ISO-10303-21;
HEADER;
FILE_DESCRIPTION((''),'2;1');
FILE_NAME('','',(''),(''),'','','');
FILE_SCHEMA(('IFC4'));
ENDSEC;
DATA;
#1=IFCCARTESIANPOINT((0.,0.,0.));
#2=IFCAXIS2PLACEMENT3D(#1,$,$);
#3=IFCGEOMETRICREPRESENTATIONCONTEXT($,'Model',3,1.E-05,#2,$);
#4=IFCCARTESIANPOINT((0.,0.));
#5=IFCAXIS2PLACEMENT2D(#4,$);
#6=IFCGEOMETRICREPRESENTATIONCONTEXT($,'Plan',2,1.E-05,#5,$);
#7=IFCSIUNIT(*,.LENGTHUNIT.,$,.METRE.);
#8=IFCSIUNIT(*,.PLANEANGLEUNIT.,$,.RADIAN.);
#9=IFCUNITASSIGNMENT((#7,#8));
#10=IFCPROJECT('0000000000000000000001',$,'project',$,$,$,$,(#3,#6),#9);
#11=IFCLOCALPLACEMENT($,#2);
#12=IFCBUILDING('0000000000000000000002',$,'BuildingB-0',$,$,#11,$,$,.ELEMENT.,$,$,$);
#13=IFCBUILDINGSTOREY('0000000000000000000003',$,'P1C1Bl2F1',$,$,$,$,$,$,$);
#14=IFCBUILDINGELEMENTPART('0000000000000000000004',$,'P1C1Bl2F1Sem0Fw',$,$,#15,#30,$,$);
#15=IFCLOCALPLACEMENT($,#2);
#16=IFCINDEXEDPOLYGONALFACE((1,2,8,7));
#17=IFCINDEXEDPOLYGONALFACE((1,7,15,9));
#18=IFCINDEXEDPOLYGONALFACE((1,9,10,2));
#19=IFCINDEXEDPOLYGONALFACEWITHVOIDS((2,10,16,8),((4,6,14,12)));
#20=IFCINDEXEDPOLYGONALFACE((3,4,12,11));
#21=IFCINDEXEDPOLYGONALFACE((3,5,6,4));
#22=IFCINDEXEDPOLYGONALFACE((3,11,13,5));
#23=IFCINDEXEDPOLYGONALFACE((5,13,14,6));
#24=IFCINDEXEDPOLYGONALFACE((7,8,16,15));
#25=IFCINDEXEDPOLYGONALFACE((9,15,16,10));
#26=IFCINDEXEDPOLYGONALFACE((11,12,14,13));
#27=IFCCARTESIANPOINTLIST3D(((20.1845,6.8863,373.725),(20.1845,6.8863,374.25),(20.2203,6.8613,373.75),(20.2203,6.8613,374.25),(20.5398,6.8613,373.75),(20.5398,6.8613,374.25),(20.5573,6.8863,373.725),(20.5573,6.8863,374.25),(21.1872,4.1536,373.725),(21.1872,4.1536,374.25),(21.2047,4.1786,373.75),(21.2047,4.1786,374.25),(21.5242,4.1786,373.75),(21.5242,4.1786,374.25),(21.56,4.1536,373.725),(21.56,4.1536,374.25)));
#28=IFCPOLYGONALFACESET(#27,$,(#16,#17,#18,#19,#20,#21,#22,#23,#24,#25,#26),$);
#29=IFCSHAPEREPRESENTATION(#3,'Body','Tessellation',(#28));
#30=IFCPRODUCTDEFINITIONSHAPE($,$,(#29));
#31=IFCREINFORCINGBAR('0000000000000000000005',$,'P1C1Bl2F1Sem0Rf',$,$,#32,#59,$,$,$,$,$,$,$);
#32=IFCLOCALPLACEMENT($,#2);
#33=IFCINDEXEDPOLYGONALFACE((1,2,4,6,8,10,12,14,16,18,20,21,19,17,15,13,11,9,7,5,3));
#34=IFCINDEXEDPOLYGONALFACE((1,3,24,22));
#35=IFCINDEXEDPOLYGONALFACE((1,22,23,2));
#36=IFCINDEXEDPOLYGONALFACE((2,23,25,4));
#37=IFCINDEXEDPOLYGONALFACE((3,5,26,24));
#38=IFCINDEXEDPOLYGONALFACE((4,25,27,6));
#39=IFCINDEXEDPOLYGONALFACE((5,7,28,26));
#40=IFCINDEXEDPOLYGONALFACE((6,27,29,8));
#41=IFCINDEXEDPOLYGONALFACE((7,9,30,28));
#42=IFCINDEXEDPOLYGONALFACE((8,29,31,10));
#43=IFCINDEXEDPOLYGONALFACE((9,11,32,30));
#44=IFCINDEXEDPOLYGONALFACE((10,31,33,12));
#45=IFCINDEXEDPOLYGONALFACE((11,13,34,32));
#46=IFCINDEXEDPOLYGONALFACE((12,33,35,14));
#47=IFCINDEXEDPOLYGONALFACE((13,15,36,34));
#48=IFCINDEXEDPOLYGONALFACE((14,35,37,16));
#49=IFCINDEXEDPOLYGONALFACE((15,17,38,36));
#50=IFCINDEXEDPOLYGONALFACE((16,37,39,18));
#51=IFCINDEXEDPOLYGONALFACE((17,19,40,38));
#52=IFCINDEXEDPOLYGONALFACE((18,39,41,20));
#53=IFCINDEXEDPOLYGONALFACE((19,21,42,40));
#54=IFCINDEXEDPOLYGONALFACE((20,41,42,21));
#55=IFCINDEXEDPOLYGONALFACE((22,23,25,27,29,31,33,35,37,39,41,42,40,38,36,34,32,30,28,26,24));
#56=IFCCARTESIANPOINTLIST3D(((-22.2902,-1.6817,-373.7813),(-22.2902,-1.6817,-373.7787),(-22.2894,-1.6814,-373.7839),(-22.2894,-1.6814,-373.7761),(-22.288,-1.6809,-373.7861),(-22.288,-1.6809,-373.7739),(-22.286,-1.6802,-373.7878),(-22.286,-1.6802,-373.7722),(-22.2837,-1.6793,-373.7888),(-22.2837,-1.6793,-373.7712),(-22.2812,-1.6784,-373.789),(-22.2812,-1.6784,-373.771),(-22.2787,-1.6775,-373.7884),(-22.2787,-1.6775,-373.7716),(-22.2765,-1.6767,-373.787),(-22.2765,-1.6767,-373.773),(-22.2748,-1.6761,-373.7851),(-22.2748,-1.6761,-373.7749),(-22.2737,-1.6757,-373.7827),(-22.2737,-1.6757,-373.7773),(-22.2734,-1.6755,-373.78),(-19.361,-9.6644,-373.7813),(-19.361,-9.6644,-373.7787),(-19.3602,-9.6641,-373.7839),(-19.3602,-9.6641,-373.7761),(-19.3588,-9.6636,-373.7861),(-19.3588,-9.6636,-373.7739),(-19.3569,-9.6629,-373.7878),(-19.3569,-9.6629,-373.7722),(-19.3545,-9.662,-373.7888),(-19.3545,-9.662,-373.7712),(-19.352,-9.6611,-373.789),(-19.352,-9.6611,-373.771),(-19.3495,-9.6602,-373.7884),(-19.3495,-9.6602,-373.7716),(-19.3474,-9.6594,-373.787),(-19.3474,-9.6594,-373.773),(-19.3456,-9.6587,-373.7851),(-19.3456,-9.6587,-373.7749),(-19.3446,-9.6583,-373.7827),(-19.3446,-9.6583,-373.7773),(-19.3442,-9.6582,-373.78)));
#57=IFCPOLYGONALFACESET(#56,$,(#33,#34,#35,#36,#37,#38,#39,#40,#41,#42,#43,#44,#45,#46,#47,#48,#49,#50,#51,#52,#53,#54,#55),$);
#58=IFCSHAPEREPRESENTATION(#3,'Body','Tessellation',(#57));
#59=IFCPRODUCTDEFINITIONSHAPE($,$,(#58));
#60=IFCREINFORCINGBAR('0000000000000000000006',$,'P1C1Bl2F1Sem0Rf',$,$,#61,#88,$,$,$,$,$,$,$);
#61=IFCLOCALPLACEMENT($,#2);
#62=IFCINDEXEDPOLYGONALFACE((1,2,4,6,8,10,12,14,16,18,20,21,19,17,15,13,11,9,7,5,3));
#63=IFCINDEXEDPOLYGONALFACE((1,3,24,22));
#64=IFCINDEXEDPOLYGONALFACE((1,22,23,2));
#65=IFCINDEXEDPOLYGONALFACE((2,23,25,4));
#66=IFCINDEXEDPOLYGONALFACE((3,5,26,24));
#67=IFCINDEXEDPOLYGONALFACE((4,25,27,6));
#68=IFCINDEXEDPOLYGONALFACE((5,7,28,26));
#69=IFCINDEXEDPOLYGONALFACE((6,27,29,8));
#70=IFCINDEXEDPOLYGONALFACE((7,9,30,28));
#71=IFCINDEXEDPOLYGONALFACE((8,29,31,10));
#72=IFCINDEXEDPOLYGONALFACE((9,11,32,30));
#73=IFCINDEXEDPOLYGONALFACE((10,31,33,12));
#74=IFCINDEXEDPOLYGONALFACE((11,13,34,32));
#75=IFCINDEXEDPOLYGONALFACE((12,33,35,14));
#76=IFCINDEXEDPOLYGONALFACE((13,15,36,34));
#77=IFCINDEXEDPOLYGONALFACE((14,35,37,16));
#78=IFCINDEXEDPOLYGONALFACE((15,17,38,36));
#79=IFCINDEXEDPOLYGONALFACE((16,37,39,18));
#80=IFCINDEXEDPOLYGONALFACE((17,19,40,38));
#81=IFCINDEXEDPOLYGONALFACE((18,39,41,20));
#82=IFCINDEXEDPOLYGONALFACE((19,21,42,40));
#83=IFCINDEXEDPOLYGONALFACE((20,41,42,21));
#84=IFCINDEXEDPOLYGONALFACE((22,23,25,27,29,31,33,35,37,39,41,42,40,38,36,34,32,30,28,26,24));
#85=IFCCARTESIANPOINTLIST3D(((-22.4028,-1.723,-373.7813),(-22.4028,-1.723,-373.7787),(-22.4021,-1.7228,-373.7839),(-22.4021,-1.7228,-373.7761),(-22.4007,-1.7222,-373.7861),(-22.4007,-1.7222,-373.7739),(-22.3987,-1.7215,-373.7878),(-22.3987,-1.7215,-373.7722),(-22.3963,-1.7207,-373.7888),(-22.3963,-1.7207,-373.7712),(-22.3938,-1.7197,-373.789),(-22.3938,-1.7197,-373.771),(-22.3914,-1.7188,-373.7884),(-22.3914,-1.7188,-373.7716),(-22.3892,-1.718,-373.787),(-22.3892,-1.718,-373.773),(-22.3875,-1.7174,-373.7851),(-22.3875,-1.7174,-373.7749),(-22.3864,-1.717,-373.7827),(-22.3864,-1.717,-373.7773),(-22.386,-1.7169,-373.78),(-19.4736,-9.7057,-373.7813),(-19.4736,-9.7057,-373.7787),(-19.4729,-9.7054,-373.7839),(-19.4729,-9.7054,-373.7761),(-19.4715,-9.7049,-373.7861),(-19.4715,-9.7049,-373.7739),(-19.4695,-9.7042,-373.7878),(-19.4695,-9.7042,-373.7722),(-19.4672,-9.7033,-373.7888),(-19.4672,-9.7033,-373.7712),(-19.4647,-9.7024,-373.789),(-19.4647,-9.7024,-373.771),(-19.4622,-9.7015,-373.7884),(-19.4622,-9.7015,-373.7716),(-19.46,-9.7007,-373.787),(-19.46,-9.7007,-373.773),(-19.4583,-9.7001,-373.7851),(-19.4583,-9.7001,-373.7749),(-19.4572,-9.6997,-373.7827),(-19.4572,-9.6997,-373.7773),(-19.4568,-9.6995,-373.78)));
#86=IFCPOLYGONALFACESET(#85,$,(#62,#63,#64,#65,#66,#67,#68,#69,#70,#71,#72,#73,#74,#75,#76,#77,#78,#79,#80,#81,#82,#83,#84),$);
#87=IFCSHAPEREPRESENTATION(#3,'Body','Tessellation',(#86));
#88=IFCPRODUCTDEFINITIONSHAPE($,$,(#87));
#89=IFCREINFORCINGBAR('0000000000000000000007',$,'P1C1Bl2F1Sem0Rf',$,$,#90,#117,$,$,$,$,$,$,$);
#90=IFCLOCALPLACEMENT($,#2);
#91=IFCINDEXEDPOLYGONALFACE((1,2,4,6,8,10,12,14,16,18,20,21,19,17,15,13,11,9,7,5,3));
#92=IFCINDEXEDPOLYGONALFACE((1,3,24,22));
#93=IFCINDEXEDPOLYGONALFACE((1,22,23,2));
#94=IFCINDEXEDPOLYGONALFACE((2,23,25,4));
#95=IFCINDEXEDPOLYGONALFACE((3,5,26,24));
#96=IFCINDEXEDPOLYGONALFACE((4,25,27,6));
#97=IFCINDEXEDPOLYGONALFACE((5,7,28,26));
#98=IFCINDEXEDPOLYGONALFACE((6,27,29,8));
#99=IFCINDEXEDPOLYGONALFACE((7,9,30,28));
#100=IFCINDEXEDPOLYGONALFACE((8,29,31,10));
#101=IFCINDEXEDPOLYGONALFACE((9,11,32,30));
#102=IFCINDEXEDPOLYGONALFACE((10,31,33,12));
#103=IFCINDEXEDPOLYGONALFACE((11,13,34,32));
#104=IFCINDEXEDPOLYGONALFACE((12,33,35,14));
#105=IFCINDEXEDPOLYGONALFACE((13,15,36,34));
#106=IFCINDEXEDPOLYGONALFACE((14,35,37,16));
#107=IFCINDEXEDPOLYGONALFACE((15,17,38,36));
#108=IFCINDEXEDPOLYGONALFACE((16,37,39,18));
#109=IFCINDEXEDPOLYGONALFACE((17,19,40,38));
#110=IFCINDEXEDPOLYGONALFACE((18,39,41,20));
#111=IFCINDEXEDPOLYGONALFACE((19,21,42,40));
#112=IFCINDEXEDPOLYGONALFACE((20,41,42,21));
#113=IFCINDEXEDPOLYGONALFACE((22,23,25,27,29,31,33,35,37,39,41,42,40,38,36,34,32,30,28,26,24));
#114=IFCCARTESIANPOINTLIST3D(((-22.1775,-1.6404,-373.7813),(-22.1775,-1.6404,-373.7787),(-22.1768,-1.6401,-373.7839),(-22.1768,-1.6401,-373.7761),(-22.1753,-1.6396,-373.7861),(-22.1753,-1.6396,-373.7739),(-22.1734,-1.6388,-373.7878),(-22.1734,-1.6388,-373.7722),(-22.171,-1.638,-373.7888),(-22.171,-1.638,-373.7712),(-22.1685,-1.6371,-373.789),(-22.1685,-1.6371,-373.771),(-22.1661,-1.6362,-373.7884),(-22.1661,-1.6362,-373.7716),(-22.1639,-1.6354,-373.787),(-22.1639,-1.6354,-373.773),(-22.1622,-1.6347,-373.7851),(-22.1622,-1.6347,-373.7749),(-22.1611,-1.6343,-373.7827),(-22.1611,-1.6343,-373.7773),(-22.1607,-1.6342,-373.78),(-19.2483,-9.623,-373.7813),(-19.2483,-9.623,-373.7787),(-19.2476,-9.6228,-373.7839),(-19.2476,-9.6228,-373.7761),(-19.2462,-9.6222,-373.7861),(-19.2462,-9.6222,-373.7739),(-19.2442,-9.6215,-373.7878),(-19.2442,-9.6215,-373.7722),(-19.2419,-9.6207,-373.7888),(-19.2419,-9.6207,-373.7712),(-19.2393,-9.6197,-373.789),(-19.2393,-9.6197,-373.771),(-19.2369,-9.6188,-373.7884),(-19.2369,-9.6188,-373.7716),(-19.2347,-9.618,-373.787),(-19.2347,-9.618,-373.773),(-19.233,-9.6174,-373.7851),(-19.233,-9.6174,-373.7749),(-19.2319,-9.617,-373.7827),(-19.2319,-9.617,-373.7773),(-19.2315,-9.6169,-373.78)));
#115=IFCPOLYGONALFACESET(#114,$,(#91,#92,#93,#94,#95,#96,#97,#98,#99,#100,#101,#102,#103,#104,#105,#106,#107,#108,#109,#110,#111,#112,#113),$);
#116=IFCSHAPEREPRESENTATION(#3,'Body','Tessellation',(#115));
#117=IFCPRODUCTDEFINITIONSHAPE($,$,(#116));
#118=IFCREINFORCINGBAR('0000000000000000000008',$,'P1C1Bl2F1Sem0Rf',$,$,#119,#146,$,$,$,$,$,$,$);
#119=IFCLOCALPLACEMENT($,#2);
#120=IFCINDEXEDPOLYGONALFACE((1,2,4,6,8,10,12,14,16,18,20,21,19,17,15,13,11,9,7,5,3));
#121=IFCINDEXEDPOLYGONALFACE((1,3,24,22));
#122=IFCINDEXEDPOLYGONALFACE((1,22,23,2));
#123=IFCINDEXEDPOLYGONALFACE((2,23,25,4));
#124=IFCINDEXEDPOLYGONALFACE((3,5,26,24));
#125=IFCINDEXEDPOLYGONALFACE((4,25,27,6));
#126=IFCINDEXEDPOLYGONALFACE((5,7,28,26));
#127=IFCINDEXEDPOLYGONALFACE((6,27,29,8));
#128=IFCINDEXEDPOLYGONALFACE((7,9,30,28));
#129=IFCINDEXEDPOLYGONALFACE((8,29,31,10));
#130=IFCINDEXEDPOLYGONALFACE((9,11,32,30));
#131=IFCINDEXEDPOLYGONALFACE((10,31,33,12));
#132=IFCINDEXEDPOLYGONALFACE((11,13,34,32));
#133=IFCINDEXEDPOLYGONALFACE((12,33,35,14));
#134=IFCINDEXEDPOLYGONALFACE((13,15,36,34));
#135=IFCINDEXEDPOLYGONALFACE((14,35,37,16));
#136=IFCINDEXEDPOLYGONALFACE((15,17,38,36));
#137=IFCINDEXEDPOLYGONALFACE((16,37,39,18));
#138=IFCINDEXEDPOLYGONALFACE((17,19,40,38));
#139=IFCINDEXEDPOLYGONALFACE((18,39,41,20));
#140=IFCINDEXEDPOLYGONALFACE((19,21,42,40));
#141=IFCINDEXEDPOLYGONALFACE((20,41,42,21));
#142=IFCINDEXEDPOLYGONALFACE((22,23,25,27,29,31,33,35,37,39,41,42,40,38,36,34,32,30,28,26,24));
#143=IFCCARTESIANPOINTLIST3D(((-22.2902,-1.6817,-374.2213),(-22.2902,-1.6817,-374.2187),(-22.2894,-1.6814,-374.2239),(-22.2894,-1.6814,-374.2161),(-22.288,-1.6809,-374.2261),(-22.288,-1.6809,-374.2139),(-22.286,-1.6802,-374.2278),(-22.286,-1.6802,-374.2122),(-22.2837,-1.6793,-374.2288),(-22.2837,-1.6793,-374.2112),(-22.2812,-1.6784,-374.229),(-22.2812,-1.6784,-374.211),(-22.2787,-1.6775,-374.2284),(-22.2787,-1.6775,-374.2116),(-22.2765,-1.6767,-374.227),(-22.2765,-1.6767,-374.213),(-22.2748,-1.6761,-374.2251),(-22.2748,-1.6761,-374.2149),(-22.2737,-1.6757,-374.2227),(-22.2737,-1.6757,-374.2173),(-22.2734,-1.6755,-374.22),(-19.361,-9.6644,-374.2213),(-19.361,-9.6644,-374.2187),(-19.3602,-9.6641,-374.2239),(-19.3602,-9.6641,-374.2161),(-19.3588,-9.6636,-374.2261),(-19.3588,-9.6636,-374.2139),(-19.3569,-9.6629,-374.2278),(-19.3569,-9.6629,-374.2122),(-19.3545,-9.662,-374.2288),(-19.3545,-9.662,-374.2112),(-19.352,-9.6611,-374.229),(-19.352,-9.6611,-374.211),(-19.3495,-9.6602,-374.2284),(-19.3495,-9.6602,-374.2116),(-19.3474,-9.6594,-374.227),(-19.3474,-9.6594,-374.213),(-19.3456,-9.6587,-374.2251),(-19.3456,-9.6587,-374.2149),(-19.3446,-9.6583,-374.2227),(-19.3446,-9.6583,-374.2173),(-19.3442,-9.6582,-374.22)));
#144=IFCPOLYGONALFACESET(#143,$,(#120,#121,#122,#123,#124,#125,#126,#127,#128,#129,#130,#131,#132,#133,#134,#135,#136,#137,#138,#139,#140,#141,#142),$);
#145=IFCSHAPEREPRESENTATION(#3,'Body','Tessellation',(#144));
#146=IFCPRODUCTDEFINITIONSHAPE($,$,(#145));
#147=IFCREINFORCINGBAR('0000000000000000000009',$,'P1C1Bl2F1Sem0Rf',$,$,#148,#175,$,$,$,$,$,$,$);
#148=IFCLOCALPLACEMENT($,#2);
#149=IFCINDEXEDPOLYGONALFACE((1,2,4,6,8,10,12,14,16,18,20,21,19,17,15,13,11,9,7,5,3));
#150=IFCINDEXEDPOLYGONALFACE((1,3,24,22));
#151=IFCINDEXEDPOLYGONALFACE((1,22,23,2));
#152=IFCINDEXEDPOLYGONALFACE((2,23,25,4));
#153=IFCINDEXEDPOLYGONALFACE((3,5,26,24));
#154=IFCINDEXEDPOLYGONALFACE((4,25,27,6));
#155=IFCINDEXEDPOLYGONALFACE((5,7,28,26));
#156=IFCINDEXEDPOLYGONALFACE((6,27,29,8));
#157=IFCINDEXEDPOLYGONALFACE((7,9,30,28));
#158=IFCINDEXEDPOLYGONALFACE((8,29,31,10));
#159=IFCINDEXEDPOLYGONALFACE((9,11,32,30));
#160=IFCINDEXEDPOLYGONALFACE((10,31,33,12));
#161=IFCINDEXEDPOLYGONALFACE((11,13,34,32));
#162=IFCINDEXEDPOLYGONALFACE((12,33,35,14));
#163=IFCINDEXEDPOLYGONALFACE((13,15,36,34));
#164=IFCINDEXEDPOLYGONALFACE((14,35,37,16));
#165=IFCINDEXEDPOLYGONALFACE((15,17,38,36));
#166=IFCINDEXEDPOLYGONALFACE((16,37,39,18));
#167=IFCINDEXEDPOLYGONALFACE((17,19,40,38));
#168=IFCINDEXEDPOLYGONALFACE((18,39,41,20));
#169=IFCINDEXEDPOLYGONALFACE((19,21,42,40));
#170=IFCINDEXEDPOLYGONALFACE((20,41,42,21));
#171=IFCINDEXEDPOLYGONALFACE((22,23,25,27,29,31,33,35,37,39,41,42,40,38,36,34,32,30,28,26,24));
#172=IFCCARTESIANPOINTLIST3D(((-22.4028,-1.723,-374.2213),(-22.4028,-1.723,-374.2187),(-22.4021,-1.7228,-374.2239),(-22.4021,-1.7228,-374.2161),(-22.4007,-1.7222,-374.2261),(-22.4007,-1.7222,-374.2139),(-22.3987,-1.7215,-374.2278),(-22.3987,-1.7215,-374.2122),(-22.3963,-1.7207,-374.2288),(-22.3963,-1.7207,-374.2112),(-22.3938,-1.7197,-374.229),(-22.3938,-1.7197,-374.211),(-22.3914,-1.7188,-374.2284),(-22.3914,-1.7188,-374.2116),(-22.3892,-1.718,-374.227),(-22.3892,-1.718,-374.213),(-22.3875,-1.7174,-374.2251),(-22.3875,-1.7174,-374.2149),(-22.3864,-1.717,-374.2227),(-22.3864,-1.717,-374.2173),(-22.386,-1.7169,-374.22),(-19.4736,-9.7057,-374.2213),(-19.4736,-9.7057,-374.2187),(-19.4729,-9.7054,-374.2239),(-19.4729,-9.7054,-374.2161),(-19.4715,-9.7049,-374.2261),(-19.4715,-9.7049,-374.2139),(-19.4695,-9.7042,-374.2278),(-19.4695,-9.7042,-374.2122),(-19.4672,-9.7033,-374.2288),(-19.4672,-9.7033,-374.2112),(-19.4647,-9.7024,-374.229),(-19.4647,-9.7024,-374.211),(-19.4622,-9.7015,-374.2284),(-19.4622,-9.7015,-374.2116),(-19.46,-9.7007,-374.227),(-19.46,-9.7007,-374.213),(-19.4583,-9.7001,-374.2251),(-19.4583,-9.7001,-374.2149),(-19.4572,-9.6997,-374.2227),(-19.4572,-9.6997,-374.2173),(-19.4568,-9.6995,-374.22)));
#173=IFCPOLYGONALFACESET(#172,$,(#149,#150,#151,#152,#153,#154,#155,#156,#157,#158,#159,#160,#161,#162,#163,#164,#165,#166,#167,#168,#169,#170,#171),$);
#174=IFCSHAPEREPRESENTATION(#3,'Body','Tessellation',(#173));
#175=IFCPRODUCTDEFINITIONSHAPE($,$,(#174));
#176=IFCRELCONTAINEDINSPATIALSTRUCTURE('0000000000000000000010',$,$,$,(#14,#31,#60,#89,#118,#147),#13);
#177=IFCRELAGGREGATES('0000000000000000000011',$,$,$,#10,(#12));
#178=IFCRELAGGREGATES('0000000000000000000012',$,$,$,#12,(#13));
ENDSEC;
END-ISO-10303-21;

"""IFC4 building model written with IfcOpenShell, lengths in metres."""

from ifc_helpers import new_model, entity, si_unit, origin, origin_2d, place, context, project, spatial, polyline, outline, extrude, element, save


model = new_model("IFC4")

# Units and contexts
model_context = context("Model", 3, precision=1e-05, world=origin())
plan_context = context("Plan", 2, precision=1e-05, world=origin_2d())
ifc_project = project(units=[si_unit("LENGTHUNIT", "METRE"), si_unit("PLANEANGLEUNIT", "RADIAN")], contexts=[model_context, plan_context])

# Building, storey
building_placement = place(None, origin())
building = spatial("IfcBuilding", under=ifc_project, at=building_placement, Name="BuildingB-0", CompositionType="ELEMENT")
storey = spatial("IfcBuildingStorey", under=building, Name="P1C1Bl2F1")

# Building element part, opening
building_element_part_1 = element("IfcBuildingElementPart", 1, inside=storey, Name="P1C1Bl2F1Sem0Fw", context=model_context, shape_type="SweptSolid", body=[
    extrude(outline(polyline([(21.1872, 4.1536, 373.725), (21.56, 4.1536, 373.725), (20.5573, 6.8863, 373.725), (20.1845, 6.8863, 373.725), (21.1872, 4.1536, 373.725)])), None, (0.0, 0.0, 1.0), 0.525),
])
element("IfcOpeningElement", 2, inside=storey, cuts=building_element_part_1, context=model_context, shape_type="SweptSolid", body=[
    extrude(outline(polyline([(21.2047, 4.1786, 373.75), (21.5242, 4.1786, 373.75), (20.5398, 6.8613, 373.75), (20.2203, 6.8613, 373.75), (21.2047, 4.1786, 373.75)])), None, (0.0, 0.0, 1.0), 0.5),
])

# Reinforcing bars
element("IfcReinforcingBar", 3, inside=storey, Name="P1C1Bl2F1Sem0Rf", context=model_context, shape_type="SweptSolid", body=[
    entity("IfcSurfaceCurveSweptAreaSolid", entity("IfcCircleProfileDef", "AREA", None, None, 0.009), None, entity("IfcPolyline", [entity("IfcCartesianPoint", [22.2818, 1.6786, 373.78]), entity("IfcCartesianPoint", [19.3526, 9.6613, 373.78])]), None, None, entity("IfcPlane", entity("IfcAxis2Placement3D", entity("IfcCartesianPoint", [22.2818, 1.6786, 373.78]), entity("IfcDirection", [0.0, 0.0, 1.0]), entity("IfcDirection", [1.0, 0.0, 0.0])))),
])
element("IfcReinforcingBar", 4, inside=storey, Name="P1C1Bl2F1Sem0Rf", context=model_context, shape_type="SweptSolid", body=[
    entity("IfcSurfaceCurveSweptAreaSolid", entity("IfcCircleProfileDef", "AREA", None, None, 0.009), None, entity("IfcPolyline", [entity("IfcCartesianPoint", [22.3945, 1.72, 373.78]), entity("IfcCartesianPoint", [19.4653, 9.7026, 373.78])]), None, None, entity("IfcPlane", entity("IfcAxis2Placement3D", entity("IfcCartesianPoint", [22.3945, 1.72, 373.78]), entity("IfcDirection", [0.0, 0.0, 1.0]), entity("IfcDirection", [1.0, 0.0, 0.0])))),
])
element("IfcReinforcingBar", 5, inside=storey, Name="P1C1Bl2F1Sem0Rf", context=model_context, shape_type="SweptSolid", body=[
    entity("IfcSurfaceCurveSweptAreaSolid", entity("IfcCircleProfileDef", "AREA", None, None, 0.009), None, entity("IfcPolyline", [entity("IfcCartesianPoint", [22.1692, 1.6373, 373.78]), entity("IfcCartesianPoint", [19.24, 9.62, 373.78])]), None, None, entity("IfcPlane", entity("IfcAxis2Placement3D", entity("IfcCartesianPoint", [22.1692, 1.6373, 373.78]), entity("IfcDirection", [0.0, 0.0, 1.0]), entity("IfcDirection", [1.0, 0.0, 0.0])))),
])
element("IfcReinforcingBar", 6, inside=storey, Name="P1C1Bl2F1Sem0Rf", context=model_context, shape_type="SweptSolid", body=[
    entity("IfcSurfaceCurveSweptAreaSolid", entity("IfcCircleProfileDef", "AREA", None, None, 0.009), None, entity("IfcPolyline", [entity("IfcCartesianPoint", [22.2818, 1.6786, 374.22]), entity("IfcCartesianPoint", [19.3526, 9.6613, 374.22])]), None, None, entity("IfcPlane", entity("IfcAxis2Placement3D", entity("IfcCartesianPoint", [22.2818, 1.6786, 374.22]), entity("IfcDirection", [0.0, 0.0, 1.0]), entity("IfcDirection", [1.0, 0.0, 0.0])))),
])
element("IfcReinforcingBar", 7, inside=storey, Name="P1C1Bl2F1Sem0Rf", context=model_context, shape_type="SweptSolid", body=[
    entity("IfcSurfaceCurveSweptAreaSolid", entity("IfcCircleProfileDef", "AREA", None, None, 0.009), None, entity("IfcPolyline", [entity("IfcCartesianPoint", [22.3945, 1.72, 374.22]), entity("IfcCartesianPoint", [19.4653, 9.7026, 374.22])]), None, None, entity("IfcPlane", entity("IfcAxis2Placement3D", entity("IfcCartesianPoint", [22.3945, 1.72, 374.22]), entity("IfcDirection", [0.0, 0.0, 1.0]), entity("IfcDirection", [1.0, 0.0, 0.0])))),
])

save(model, "model.ifc")
